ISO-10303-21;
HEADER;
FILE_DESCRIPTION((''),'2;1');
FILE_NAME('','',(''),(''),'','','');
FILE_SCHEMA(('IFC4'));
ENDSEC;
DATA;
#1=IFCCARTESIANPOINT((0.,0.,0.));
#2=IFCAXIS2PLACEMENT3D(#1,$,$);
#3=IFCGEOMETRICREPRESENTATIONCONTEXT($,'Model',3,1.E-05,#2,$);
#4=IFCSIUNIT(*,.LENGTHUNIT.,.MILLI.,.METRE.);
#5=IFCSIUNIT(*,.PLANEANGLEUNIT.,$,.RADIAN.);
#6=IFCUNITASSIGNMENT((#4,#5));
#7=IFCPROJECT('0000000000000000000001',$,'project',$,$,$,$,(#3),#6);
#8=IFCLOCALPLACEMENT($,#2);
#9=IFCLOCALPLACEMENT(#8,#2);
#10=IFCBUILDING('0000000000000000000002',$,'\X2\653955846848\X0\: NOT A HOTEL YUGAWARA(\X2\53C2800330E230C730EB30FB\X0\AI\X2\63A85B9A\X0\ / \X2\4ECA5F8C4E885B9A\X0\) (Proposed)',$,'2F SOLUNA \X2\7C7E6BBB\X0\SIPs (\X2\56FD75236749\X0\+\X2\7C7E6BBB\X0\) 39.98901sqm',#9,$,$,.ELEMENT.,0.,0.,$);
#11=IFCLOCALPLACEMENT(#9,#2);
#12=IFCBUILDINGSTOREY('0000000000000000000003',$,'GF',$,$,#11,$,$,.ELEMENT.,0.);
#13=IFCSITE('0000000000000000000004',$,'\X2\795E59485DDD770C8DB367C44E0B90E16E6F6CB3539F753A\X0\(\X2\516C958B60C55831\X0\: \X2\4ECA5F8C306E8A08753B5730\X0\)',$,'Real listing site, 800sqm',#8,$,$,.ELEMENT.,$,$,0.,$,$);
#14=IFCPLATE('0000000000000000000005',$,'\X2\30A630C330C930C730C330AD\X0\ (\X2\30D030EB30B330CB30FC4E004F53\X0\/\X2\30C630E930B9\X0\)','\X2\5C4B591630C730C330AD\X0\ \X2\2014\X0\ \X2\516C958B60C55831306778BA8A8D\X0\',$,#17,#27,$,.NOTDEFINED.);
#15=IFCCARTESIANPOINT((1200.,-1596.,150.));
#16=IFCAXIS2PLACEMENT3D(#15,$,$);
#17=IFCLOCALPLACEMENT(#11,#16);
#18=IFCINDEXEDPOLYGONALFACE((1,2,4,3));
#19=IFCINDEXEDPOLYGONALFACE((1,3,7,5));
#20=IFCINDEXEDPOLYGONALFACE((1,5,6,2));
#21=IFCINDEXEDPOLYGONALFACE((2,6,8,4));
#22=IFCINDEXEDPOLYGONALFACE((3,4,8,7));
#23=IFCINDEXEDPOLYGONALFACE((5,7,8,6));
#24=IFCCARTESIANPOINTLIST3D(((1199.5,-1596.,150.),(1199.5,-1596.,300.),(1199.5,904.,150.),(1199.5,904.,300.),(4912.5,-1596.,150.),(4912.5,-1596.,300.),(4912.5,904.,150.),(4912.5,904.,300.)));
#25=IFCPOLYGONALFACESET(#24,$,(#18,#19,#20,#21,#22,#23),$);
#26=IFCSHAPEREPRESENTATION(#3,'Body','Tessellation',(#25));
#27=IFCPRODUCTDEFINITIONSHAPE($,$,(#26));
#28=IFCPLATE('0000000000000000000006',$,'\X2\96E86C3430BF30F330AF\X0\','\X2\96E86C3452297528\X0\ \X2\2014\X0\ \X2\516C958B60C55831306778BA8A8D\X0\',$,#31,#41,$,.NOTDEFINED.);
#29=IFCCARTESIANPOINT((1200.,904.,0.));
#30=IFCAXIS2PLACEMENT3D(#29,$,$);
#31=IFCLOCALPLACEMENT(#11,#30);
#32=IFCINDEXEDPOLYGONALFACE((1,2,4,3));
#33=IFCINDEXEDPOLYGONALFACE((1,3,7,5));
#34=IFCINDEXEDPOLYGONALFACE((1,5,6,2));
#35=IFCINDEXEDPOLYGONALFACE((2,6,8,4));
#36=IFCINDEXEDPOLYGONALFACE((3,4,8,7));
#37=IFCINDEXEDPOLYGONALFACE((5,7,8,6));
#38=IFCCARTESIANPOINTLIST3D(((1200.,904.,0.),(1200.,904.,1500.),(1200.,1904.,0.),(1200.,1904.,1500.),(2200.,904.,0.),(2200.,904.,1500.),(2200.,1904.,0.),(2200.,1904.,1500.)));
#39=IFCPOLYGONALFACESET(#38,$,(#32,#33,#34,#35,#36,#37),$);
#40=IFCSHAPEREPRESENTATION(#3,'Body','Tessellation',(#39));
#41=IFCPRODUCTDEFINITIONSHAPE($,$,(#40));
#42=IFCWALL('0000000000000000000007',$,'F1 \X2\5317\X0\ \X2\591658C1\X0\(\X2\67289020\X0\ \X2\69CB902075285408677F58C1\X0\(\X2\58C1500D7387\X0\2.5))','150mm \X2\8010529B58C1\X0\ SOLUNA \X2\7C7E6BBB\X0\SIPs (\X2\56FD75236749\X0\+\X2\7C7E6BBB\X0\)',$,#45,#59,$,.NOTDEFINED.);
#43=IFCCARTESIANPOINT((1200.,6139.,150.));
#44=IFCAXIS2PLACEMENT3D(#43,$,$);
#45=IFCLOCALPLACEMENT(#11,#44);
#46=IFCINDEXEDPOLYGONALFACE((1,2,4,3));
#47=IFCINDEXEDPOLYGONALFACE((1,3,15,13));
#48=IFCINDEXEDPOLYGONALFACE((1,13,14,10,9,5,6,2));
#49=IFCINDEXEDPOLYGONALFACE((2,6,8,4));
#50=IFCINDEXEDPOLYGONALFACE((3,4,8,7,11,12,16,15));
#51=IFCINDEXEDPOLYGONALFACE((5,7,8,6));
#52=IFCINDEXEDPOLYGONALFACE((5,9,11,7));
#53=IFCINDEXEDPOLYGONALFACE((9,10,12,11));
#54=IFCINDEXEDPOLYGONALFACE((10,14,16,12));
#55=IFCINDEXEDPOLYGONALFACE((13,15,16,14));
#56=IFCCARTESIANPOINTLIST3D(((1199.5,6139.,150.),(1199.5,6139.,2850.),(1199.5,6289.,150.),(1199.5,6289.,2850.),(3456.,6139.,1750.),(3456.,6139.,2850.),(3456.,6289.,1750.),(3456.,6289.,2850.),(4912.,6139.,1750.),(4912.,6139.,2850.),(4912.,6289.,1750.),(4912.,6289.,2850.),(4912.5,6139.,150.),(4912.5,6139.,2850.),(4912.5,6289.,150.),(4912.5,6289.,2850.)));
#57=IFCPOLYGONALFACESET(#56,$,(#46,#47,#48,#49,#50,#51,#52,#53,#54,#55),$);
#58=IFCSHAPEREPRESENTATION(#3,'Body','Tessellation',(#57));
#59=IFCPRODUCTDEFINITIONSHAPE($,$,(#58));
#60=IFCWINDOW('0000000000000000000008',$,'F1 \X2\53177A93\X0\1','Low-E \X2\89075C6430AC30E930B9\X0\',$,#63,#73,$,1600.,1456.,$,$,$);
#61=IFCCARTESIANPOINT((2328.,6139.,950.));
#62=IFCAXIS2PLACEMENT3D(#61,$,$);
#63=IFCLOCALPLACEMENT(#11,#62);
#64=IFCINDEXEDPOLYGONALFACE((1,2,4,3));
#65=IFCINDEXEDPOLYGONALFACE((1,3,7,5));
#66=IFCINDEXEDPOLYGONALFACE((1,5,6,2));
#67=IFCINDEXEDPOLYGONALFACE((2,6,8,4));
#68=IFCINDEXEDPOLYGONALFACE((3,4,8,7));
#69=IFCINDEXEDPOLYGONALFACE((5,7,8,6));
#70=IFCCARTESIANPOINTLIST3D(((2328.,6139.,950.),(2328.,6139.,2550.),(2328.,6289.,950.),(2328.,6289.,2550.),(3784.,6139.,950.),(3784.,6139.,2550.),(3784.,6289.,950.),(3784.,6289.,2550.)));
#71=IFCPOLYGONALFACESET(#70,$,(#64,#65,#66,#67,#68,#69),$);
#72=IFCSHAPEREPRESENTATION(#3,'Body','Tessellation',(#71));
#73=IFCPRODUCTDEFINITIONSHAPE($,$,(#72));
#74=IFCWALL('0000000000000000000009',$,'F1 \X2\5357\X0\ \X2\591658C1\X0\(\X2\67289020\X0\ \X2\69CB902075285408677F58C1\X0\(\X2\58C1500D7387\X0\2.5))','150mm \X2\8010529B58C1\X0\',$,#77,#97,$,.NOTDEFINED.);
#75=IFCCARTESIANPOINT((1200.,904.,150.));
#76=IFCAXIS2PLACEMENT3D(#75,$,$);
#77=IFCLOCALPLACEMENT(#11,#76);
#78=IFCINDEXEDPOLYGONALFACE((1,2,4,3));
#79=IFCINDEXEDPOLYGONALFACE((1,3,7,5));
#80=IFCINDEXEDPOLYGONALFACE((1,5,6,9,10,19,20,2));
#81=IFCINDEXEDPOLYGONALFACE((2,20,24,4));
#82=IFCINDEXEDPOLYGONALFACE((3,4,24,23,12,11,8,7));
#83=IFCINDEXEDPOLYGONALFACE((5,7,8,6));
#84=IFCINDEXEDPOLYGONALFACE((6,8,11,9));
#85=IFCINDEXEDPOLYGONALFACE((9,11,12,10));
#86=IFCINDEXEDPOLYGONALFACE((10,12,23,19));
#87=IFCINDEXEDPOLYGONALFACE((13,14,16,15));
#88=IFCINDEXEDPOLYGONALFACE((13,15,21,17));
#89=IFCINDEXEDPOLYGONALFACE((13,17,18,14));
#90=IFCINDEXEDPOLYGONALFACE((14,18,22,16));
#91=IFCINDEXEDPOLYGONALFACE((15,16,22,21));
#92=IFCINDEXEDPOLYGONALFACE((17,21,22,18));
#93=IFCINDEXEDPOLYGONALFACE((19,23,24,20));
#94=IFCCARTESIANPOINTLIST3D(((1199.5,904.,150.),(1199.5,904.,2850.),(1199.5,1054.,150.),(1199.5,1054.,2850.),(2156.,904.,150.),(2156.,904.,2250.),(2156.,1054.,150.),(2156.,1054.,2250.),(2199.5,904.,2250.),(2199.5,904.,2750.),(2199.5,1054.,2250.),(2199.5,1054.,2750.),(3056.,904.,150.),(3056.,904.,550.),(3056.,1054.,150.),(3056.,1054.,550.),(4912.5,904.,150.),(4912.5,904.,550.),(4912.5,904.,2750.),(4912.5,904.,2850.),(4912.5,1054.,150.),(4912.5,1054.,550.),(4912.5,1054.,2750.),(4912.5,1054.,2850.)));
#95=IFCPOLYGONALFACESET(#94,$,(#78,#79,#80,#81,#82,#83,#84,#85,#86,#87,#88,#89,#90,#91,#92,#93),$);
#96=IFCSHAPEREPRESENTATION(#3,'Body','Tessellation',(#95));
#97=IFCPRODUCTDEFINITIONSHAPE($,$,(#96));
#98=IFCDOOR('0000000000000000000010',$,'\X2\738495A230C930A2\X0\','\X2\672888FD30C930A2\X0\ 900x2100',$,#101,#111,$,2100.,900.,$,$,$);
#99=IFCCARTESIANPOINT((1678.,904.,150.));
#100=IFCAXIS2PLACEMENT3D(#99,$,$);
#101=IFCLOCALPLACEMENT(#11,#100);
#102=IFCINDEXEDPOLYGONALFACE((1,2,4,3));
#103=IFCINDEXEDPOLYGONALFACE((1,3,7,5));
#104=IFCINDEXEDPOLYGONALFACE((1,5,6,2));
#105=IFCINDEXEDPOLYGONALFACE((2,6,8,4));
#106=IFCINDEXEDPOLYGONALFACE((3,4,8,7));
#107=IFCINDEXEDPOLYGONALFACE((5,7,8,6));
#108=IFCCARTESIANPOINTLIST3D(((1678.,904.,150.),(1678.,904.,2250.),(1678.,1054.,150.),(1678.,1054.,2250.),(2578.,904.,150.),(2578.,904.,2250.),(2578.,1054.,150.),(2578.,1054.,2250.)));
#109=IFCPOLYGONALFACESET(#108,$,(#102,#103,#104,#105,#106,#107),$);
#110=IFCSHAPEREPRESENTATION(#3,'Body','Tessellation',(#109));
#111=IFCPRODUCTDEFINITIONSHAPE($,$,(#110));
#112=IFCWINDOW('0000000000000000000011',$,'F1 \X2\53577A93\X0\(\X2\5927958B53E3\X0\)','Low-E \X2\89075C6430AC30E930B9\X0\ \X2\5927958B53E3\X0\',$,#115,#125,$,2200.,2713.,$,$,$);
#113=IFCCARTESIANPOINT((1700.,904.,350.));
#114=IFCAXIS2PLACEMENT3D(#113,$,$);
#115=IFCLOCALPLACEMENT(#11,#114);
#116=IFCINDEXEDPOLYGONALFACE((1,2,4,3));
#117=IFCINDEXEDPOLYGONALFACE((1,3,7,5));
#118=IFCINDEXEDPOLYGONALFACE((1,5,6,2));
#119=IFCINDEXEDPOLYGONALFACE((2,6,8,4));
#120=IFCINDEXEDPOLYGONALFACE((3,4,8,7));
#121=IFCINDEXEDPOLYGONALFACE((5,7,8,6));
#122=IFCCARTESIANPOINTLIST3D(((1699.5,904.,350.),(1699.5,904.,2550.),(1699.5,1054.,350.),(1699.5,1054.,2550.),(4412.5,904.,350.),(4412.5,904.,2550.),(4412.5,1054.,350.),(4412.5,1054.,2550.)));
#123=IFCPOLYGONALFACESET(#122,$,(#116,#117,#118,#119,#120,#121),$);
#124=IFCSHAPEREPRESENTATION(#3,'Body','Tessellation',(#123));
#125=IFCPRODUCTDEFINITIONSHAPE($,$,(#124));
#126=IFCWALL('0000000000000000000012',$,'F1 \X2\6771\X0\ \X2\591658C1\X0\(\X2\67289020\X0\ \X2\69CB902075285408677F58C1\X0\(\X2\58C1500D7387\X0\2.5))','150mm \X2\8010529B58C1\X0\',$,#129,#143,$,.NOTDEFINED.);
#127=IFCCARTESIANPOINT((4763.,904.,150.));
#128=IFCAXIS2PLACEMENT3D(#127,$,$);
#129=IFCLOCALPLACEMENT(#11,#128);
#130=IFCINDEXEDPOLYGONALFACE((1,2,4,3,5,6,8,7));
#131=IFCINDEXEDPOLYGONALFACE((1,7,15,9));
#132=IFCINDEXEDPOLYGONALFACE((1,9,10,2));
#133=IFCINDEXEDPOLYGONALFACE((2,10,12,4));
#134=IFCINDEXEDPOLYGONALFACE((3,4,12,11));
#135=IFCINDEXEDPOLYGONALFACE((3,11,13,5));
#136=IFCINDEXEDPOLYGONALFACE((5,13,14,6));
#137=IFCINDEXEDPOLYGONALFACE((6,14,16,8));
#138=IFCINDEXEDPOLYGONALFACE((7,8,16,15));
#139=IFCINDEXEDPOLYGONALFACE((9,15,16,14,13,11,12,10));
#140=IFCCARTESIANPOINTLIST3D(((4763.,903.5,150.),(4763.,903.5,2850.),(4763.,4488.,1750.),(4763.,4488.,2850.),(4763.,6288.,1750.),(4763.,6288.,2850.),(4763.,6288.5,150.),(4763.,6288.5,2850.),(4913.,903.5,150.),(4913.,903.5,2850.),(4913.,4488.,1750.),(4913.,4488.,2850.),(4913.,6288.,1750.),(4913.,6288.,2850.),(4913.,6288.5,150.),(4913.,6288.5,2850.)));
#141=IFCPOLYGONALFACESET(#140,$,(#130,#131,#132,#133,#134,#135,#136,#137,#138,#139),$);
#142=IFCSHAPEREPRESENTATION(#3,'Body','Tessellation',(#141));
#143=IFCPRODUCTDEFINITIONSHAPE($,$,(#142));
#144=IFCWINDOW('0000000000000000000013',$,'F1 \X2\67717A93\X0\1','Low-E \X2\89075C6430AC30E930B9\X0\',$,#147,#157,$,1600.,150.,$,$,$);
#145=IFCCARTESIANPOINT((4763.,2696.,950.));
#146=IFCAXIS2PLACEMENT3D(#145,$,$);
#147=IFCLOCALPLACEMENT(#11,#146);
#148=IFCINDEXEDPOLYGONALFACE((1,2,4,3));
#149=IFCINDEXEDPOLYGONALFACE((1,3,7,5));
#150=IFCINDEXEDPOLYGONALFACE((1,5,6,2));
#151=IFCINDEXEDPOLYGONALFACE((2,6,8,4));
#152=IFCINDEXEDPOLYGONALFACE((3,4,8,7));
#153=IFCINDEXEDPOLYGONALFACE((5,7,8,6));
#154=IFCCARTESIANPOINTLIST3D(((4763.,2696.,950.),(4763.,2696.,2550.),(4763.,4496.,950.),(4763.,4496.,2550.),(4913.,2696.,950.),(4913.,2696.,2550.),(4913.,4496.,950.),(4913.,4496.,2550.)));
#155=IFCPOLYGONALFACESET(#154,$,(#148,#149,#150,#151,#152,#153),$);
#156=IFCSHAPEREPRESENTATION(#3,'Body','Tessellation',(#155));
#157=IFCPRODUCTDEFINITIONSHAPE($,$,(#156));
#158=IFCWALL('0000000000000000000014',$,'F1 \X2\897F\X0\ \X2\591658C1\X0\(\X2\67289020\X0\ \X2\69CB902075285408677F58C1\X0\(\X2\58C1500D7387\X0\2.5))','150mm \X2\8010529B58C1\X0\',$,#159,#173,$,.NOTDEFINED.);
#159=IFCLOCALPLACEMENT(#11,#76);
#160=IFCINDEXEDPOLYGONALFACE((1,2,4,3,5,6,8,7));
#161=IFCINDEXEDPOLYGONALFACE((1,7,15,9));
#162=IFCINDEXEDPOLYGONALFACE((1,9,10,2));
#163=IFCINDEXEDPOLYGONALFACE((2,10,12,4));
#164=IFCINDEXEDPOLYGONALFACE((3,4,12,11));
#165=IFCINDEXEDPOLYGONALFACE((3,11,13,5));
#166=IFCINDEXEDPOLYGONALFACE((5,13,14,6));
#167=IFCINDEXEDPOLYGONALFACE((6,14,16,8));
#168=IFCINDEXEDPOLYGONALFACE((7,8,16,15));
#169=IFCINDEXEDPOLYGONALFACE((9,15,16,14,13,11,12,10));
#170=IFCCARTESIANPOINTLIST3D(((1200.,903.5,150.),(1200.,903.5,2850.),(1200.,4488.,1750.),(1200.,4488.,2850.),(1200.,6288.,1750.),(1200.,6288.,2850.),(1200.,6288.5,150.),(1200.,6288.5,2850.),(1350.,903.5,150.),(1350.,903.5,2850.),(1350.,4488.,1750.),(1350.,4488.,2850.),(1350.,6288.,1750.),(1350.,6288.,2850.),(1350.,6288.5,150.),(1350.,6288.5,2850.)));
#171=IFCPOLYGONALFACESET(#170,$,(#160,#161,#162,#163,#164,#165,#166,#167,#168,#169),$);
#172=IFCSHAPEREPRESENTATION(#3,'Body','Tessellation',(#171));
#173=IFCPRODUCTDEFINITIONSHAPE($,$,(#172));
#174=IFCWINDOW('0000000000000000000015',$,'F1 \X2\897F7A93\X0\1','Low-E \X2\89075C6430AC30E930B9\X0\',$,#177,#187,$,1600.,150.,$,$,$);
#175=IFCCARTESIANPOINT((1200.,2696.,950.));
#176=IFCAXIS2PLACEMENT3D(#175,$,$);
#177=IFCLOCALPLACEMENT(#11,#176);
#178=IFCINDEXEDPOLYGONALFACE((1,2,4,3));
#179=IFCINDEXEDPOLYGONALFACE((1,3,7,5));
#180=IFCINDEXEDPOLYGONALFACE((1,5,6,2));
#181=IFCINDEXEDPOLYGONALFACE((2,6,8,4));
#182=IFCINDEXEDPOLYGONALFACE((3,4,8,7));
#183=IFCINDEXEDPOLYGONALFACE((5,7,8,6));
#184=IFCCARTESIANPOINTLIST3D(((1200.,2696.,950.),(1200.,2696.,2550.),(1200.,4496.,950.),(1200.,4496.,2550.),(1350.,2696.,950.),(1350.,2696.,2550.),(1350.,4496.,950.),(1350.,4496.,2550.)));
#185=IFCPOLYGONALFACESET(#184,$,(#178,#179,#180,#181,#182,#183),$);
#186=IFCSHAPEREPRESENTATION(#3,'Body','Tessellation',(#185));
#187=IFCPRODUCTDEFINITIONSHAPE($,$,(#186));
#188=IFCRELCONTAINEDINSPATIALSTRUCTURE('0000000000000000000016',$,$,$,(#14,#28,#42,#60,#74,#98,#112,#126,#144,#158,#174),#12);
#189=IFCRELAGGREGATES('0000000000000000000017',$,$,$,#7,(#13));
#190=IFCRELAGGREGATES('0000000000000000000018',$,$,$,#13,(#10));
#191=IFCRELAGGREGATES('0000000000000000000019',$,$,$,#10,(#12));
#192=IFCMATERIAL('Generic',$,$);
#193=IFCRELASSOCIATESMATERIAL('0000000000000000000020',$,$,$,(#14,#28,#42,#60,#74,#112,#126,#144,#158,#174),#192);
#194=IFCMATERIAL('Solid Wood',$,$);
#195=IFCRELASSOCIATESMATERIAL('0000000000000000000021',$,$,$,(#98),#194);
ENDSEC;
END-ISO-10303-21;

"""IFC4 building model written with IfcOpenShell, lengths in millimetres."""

from ifc_helpers import new_model, si_unit, frame, frame_2d, origin, place, context, project, spatial, rectangle, extrude, material, element, fill, save


model = new_model("IFC4")

# Units and contexts
model_context = context("Model", 3, precision=1e-05, world=origin())
ifc_project = project(units=[si_unit("LENGTHUNIT", "METRE", prefix="MILLI"), si_unit("PLANEANGLEUNIT", "RADIAN")], contexts=[model_context])

# Site, building, storey
site_placement = place(None, origin())
site = spatial("IfcSite", under=ifc_project, at=site_placement, Name="神奈川県足柄下郡湯河原町(公開情報: 今後の計画地)", ObjectType="Real listing site, 800sqm", CompositionType="ELEMENT", RefElevation=0.0)
building_placement = place(site_placement, origin())
building = spatial("IfcBuilding", under=site, at=building_placement, Name="改善案: NOT A HOTEL YUGAWARA(参考モデル・AI推定 / 今後予定) (Proposed)", ObjectType="2F SOLUNA 籾殻SIPs (国産杉+籾殻) 39.98901sqm", CompositionType="ELEMENT", ElevationOfRefHeight=0.0, ElevationOfTerrain=0.0)
storey_placement = place(building_placement, origin())
storey = spatial("IfcBuildingStorey", under=building, at=storey_placement, Name="GF", CompositionType="ELEMENT", Elevation=0.0)

# Shared definitions
ifc_material_1 = material(Name="Generic")

# Plates
plate_1_placement = place(storey_placement, frame((1200.0, -1596.0, 150.0)))
element("IfcPlate", 1, at=plate_1_placement, inside=storey, material=ifc_material_1, Name="ウッドデッキ (バルコニー一体/テラス)", Description="屋外デッキ — 公開情報で確認", PredefinedType="NOTDEFINED", context=model_context, shape_type="SweptSolid", body=[
    extrude(rectangle(XDim=3713.0, YDim=2500.0, at=frame_2d((1856.0, 1250.0))), frame((1200.0, -1596.0, 150.0)), (0.0, 0.0, 1.0), 150.0),
])
plate_2_placement = place(storey_placement, frame((1200.0, 904.0, 0.0)))
element("IfcPlate", 2, at=plate_2_placement, inside=storey, material=ifc_material_1, Name="雨水タンク", Description="雨水利用 — 公開情報で確認", PredefinedType="NOTDEFINED", context=model_context, shape_type="SweptSolid", body=[
    extrude(rectangle(XDim=1000.0, YDim=1000.0, at=frame_2d((500.0, 500.0))), frame((1200.0, 904.0, 0.0)), (0.0, 0.0, 1.0), 1500.0),
])

# Wall, opening, window
wall_1_placement = place(storey_placement, frame((1200.0, 6139.0, 150.0)))
wall_1 = element("IfcWall", 3, at=wall_1_placement, inside=storey, material=ifc_material_1, Name="F1 北 外壁(木造 構造用合板壁(壁倍率2.5))", Description="150mm 耐力壁 SOLUNA 籾殻SIPs (国産杉+籾殻)", PredefinedType="NOTDEFINED", context=model_context, shape_type="SweptSolid", body=[
    extrude(rectangle(XDim=3713.0, YDim=150.0, at=frame_2d((1856.0, 75.0))), frame((1200.0, 6139.0, 150.0)), (0.0, 0.0, 1.0), 2700.0),
])
opening_1_placement = place(storey_placement, frame((2328.0, 6139.0, 950.0)))
opening_1 = element("IfcOpeningElement", 4, at=opening_1_placement, cuts=wall_1, PredefinedType="NOTDEFINED", context=model_context, shape_type="SweptSolid", body=[
    extrude(rectangle(XDim=1456.0, YDim=150.0, at=frame_2d((728.0, 75.0))), frame((2328.0, 6139.0, 950.0)), (0.0, 0.0, 1.0), 1600.0),
])
window_1_placement = place(storey_placement, frame((2328.0, 6139.0, 950.0)))
window_1 = element("IfcWindow", 5, at=window_1_placement, inside=storey, material=ifc_material_1, Name="F1 北窓1", Description="Low-E 複層ガラス", OverallHeight=1600.0, OverallWidth=1456.0, context=model_context, shape_type="SweptSolid", body=[
    extrude(rectangle(XDim=1456.0, YDim=150.0, at=frame_2d((728.0, 75.0))), frame((2328.0, 6139.0, 950.0)), (0.0, 0.0, 1.0), 1600.0),
])
fill(opening_1, window_1)

# Wall, openings, door, window
wall_2_placement = place(storey_placement, frame((1200.0, 904.0, 150.0)))
wall_2 = element("IfcWall", 6, at=wall_2_placement, inside=storey, material=ifc_material_1, Name="F1 南 外壁(木造 構造用合板壁(壁倍率2.5))", Description="150mm 耐力壁", PredefinedType="NOTDEFINED", context=model_context, shape_type="SweptSolid", body=[
    extrude(rectangle(XDim=3713.0, YDim=150.0, at=frame_2d((1856.0, 75.0))), frame((1200.0, 904.0, 150.0)), (0.0, 0.0, 1.0), 2700.0),
])
opening_2_placement = place(storey_placement, frame((1678.0, 904.0, 150.0)))
opening_2 = element("IfcOpeningElement", 7, at=opening_2_placement, cuts=wall_2, PredefinedType="NOTDEFINED", context=model_context, shape_type="SweptSolid", body=[
    extrude(rectangle(XDim=900.0, YDim=150.0, at=frame_2d((450.0, 75.0))), frame((1678.0, 904.0, 150.0)), (0.0, 0.0, 1.0), 2100.0),
])
opening_3_placement = place(storey_placement, frame((1700.0, 904.0, 350.0)))
opening_3 = element("IfcOpeningElement", 8, at=opening_3_placement, cuts=wall_2, PredefinedType="NOTDEFINED", context=model_context, shape_type="SweptSolid", body=[
    extrude(rectangle(XDim=2713.0, YDim=150.0, at=frame_2d((1356.0, 75.0))), frame((1700.0, 904.0, 350.0)), (0.0, 0.0, 1.0), 2200.0),
])
ifc_material_2 = material(Name="Solid Wood")
door_placement = place(storey_placement, frame((1678.0, 904.0, 150.0)))
door = element("IfcDoor", 9, at=door_placement, inside=storey, material=ifc_material_2, Name="玄関ドア", Description="木製ドア 900x2100", OverallHeight=2100.0, OverallWidth=900.0, context=model_context, shape_type="SweptSolid", body=[
    extrude(rectangle(XDim=900.0, YDim=150.0, at=frame_2d((450.0, 75.0))), frame((1678.0, 904.0, 150.0)), (0.0, 0.0, 1.0), 2100.0),
])
fill(opening_2, door)
window_2_placement = place(storey_placement, frame((1700.0, 904.0, 350.0)))
window_2 = element("IfcWindow", 10, at=window_2_placement, inside=storey, material=ifc_material_1, Name="F1 南窓(大開口)", Description="Low-E 複層ガラス 大開口", OverallHeight=2200.0, OverallWidth=2713.0, context=model_context, shape_type="SweptSolid", body=[
    extrude(rectangle(XDim=2713.0, YDim=150.0, at=frame_2d((1356.0, 75.0))), frame((1700.0, 904.0, 350.0)), (0.0, 0.0, 1.0), 2200.0),
])
fill(opening_3, window_2)

# Walls, openings, windows
wall_3_placement = place(storey_placement, frame((4763.0, 904.0, 150.0)))
wall_3 = element("IfcWall", 11, at=wall_3_placement, inside=storey, material=ifc_material_1, Name="F1 東 外壁(木造 構造用合板壁(壁倍率2.5))", Description="150mm 耐力壁", PredefinedType="NOTDEFINED", context=model_context, shape_type="SweptSolid", body=[
    extrude(rectangle(XDim=150.0, YDim=5385.0, at=frame_2d((75.0, 2692.0))), frame((4763.0, 904.0, 150.0)), (0.0, 0.0, 1.0), 2700.0),
])
opening_4_placement = place(storey_placement, frame((4763.0, 2696.0, 950.0)))
opening_4 = element("IfcOpeningElement", 12, at=opening_4_placement, cuts=wall_3, PredefinedType="NOTDEFINED", context=model_context, shape_type="SweptSolid", body=[
    extrude(rectangle(XDim=150.0, YDim=1800.0, at=frame_2d((75.0, 900.0))), frame((4763.0, 2696.0, 950.0)), (0.0, 0.0, 1.0), 1600.0),
])
window_3_placement = place(storey_placement, frame((4763.0, 2696.0, 950.0)))
window_3 = element("IfcWindow", 13, at=window_3_placement, inside=storey, material=ifc_material_1, Name="F1 東窓1", Description="Low-E 複層ガラス", OverallHeight=1600.0, OverallWidth=150.0, context=model_context, shape_type="SweptSolid", body=[
    extrude(rectangle(XDim=150.0, YDim=1800.0, at=frame_2d((75.0, 900.0))), frame((4763.0, 2696.0, 950.0)), (0.0, 0.0, 1.0), 1600.0),
])
fill(opening_4, window_3)
wall_4_placement = place(storey_placement, frame((1200.0, 904.0, 150.0)))
wall_4 = element("IfcWall", 14, at=wall_4_placement, inside=storey, material=ifc_material_1, Name="F1 西 外壁(木造 構造用合板壁(壁倍率2.5))", Description="150mm 耐力壁", PredefinedType="NOTDEFINED", context=model_context, shape_type="SweptSolid", body=[
    extrude(rectangle(XDim=150.0, YDim=5385.0, at=frame_2d((75.0, 2692.0))), frame((1200.0, 904.0, 150.0)), (0.0, 0.0, 1.0), 2700.0),
])
opening_5_placement = place(storey_placement, frame((1200.0, 2696.0, 950.0)))
opening_5 = element("IfcOpeningElement", 15, at=opening_5_placement, cuts=wall_4, PredefinedType="NOTDEFINED", context=model_context, shape_type="SweptSolid", body=[
    extrude(rectangle(XDim=150.0, YDim=1800.0, at=frame_2d((75.0, 900.0))), frame((1200.0, 2696.0, 950.0)), (0.0, 0.0, 1.0), 1600.0),
])
window_4_placement = place(storey_placement, frame((1200.0, 2696.0, 950.0)))
window_4 = element("IfcWindow", 16, at=window_4_placement, inside=storey, material=ifc_material_1, Name="F1 西窓1", Description="Low-E 複層ガラス", OverallHeight=1600.0, OverallWidth=150.0, context=model_context, shape_type="SweptSolid", body=[
    extrude(rectangle(XDim=150.0, YDim=1800.0, at=frame_2d((75.0, 900.0))), frame((1200.0, 2696.0, 950.0)), (0.0, 0.0, 1.0), 1600.0),
])
fill(opening_5, window_4)

save(model, "model.ifc")
